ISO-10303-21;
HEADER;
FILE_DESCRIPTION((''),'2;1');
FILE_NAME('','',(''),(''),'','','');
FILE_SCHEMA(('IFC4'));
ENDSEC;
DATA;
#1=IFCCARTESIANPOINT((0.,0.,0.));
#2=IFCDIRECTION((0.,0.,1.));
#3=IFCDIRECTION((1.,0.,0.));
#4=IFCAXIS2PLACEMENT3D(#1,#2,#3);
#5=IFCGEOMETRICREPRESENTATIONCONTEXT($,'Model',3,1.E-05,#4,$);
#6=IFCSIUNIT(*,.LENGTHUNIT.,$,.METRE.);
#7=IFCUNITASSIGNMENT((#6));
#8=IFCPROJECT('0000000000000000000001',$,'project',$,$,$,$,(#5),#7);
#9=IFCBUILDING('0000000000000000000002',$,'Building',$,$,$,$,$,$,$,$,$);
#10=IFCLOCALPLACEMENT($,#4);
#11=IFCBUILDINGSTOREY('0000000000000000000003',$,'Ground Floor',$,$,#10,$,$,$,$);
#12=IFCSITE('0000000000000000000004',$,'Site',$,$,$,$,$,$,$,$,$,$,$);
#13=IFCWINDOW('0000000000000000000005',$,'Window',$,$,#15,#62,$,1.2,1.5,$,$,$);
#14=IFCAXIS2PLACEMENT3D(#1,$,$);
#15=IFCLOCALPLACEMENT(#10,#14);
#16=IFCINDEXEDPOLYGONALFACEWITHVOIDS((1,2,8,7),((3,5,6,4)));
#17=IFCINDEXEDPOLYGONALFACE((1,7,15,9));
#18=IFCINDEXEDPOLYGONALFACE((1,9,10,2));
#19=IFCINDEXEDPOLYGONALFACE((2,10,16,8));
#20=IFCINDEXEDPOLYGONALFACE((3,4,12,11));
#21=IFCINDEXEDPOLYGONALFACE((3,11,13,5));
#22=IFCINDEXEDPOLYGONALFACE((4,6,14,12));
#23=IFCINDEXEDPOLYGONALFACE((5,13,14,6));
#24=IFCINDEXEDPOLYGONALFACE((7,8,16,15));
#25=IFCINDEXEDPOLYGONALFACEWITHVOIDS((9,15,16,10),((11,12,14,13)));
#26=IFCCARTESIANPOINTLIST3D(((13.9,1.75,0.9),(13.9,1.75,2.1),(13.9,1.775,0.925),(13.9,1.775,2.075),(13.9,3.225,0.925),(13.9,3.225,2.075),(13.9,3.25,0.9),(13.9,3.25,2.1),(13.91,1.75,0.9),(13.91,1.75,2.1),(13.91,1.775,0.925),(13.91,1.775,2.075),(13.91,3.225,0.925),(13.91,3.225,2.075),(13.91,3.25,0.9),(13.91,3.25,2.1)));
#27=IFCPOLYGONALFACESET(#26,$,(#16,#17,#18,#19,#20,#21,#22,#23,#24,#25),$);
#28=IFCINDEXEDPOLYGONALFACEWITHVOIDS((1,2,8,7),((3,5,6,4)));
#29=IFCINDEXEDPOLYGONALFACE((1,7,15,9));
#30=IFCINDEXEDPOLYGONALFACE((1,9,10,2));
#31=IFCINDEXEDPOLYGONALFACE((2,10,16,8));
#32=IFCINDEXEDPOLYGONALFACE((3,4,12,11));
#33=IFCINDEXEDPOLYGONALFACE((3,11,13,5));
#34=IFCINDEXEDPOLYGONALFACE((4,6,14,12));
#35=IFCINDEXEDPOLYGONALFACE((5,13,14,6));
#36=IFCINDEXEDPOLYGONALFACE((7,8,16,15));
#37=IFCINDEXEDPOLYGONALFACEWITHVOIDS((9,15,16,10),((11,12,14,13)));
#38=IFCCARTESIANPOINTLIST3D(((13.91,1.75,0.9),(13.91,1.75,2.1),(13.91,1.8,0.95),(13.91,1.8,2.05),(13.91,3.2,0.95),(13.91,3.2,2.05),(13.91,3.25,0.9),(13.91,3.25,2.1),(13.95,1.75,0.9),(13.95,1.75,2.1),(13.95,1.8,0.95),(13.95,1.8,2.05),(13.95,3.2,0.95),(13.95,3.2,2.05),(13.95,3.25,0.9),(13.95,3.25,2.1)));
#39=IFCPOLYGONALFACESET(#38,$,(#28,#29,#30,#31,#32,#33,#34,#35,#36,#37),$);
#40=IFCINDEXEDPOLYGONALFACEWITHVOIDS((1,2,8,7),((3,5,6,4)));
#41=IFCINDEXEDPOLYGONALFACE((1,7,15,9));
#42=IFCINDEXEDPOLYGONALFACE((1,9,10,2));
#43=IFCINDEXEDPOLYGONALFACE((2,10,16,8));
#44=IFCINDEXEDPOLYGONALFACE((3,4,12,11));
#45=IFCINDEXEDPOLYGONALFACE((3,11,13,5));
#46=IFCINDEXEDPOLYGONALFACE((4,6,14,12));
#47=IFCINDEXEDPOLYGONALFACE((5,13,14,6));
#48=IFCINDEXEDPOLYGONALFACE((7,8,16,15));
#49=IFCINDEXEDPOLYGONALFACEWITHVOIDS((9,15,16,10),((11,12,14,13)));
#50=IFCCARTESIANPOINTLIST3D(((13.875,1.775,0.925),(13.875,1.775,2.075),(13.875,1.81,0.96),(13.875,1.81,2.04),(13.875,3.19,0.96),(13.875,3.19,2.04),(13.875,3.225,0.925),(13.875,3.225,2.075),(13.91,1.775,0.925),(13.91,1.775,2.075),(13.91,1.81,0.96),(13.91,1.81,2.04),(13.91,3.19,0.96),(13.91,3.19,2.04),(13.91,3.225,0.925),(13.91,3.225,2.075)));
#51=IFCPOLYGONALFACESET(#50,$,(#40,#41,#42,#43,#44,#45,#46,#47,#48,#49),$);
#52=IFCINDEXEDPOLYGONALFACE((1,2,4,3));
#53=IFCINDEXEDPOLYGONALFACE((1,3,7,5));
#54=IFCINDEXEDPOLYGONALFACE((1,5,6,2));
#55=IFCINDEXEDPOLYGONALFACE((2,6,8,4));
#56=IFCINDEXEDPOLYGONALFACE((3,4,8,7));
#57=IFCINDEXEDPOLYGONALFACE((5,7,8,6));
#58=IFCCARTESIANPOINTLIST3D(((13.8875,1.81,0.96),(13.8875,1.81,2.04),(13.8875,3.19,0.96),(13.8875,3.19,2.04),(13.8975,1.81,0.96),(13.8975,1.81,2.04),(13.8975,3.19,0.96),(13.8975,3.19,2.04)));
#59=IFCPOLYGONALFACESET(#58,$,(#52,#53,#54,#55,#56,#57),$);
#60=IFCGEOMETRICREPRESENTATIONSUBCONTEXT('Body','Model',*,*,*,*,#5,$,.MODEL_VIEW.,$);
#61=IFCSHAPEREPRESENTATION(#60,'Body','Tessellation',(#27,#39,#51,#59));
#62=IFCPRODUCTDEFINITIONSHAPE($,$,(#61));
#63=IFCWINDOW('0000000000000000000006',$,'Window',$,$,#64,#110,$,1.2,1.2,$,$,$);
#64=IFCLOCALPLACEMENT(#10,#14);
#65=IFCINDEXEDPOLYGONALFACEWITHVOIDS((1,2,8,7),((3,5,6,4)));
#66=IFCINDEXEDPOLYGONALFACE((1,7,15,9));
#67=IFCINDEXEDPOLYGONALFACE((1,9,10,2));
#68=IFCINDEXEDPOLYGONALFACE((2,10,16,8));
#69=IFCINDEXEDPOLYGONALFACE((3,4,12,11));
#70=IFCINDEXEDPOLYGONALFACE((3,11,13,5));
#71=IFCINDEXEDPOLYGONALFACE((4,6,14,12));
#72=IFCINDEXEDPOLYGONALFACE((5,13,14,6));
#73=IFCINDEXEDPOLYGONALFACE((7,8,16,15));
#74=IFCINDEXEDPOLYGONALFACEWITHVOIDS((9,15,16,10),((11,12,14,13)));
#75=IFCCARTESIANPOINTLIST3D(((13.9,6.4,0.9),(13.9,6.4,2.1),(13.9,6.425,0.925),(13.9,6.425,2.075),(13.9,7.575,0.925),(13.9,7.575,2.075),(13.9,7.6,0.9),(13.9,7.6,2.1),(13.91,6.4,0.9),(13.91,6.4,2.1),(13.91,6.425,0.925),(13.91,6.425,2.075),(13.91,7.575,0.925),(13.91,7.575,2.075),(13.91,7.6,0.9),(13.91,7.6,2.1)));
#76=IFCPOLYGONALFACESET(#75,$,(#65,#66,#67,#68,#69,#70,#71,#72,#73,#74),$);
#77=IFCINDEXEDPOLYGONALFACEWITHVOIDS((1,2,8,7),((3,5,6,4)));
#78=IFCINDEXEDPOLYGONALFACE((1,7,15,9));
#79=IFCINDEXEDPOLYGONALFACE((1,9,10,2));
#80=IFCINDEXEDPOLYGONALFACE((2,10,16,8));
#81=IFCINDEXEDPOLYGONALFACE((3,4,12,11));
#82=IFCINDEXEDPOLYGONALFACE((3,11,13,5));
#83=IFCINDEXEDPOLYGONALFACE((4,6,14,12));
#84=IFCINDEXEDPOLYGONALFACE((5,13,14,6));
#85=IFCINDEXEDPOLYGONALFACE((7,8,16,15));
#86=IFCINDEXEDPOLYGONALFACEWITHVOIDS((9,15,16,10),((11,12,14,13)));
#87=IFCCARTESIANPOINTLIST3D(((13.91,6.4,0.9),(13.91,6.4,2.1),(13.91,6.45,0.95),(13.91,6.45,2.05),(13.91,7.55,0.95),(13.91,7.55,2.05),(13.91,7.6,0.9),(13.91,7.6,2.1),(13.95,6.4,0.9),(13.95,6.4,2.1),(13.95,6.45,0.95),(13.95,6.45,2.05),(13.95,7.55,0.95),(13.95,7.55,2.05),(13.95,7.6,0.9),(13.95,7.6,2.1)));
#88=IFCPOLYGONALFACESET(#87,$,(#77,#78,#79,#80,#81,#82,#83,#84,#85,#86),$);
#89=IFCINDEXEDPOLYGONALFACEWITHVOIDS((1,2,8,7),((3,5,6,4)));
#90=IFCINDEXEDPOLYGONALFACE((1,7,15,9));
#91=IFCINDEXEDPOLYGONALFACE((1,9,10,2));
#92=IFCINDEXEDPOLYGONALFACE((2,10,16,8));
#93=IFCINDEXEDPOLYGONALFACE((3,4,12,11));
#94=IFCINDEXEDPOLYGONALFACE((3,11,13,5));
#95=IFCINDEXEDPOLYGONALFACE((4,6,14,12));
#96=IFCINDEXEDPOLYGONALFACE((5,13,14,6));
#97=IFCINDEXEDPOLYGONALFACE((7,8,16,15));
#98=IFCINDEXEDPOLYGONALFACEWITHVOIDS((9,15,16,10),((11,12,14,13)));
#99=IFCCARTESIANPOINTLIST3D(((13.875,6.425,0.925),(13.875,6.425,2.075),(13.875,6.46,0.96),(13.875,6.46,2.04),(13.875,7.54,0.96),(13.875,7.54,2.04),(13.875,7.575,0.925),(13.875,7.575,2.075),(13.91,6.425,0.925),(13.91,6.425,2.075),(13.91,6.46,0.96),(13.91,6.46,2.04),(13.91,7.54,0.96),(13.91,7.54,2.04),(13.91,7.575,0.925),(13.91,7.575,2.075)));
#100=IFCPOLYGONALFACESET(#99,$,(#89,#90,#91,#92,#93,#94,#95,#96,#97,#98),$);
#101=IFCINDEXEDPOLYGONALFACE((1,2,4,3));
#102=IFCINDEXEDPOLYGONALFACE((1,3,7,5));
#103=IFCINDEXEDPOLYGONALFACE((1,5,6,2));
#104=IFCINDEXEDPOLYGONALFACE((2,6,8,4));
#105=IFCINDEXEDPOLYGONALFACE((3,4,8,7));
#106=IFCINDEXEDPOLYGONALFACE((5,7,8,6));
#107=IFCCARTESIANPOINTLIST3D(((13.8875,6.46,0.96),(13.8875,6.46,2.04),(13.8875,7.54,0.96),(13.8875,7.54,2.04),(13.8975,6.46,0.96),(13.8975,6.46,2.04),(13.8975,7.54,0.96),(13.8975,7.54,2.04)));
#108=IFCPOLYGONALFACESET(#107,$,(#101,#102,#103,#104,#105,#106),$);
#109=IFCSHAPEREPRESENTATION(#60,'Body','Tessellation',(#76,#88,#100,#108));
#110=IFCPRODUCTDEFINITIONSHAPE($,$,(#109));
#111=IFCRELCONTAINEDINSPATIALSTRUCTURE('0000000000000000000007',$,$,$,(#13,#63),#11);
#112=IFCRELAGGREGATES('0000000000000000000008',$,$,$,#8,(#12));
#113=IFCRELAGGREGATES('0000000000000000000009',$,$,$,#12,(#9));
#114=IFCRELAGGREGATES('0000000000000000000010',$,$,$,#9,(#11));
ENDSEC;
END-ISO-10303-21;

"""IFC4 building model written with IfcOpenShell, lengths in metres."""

from ifc_helpers import new_model, si_unit, frame, origin_with_axes, place, context, subcontext, project, spatial, line, indexed_curve, outline, extrude, element, save


model = new_model("IFC4")

# Units and contexts
model_context = context("Model", 3, precision=1e-05, world=origin_with_axes())
body_context = subcontext(model_context, "Body", "Model", "MODEL_VIEW")
ifc_project = project(units=[si_unit("LENGTHUNIT", "METRE")], contexts=[model_context])

# Site, building, storey
site = spatial("IfcSite", under=ifc_project, Name="Site")
building = spatial("IfcBuilding", under=site, Name="Building")
storey_placement = place(None, origin_with_axes())
storey = spatial("IfcBuildingStorey", under=building, at=storey_placement, Name="Ground Floor")

# Windows
for number, where, z_axis, x_axis, name in (
    (1, (14.0, 1.75, 0.9), (0.0, 0.0, 1.0), (0.0, 1.0, 0.0), "Window"),
):
    element("IfcWindow", number, at=place(storey_placement, frame(where, z_axis=z_axis, x_axis=x_axis)), inside=storey, Name=name, OverallHeight=1.2, OverallWidth=1.5, context=body_context, shape_type="SweptSolid", body=[
        extrude(outline(indexed_curve([(0.0, 0.0), (1.5, 0.0), (1.5, 1.2), (0.0, 1.2)], segments=[line(1, 2, 3, 4, 1)]), holes=[indexed_curve([(0.025, 0.025), (1.475, 0.025), (1.475, 1.175), (0.025, 1.175)], segments=[line(1, 2, 3, 4, 1)])]), frame((0.0, 0.09, 0.0), z_axis=(0.0, -1.0, 0.0), x_axis=(1.0, 0.0, 0.0)), (0.0, 0.0, -1.0), 0.01),
        extrude(outline(indexed_curve([(0.0, 0.0), (1.5, 0.0), (1.5, 1.2), (0.0, 1.2)], segments=[line(1, 2, 3, 4, 1)]), holes=[indexed_curve([(0.05, 0.05), (1.45, 0.05), (1.45, 1.15), (0.05, 1.15)], segments=[line(1, 2, 3, 4, 1)])]), frame((0.0, 0.05, 0.0), z_axis=(0.0, -1.0, 0.0), x_axis=(1.0, 0.0, 0.0)), (0.0, 0.0, -1.0), 0.04),
        extrude(outline(indexed_curve([(0.0, 0.0), (1.45, 0.0), (1.45, 1.15), (0.0, 1.15)], segments=[line(1, 2, 3, 4, 1)]), holes=[indexed_curve([(0.035, 0.035), (1.415, 0.035), (1.415, 1.115), (0.035, 1.115)], segments=[line(1, 2, 3, 4, 1)])]), frame((0.025, 0.09, 0.025), z_axis=(0.0, -1.0, 0.0), x_axis=(1.0, 0.0, 0.0)), (0.0, 0.0, -1.0), 0.035),
        extrude(outline(indexed_curve([(0.035, 0.035), (1.415, 0.035), (1.415, 1.115), (0.035, 1.115)], segments=[line(1, 2, 3, 4, 1)])), frame((0.025, 0.1025, 0.025), z_axis=(0.0, -1.0, 0.0), x_axis=(1.0, 0.0, 0.0)), (0.0, 0.0, -1.0), 0.01),
    ])
window_1_placement = place(storey_placement, frame((14.0, 6.4, 0.9), z_axis=(0.0, 0.0, 1.0), x_axis=(0.0, 1.0, 0.0)))
element("IfcWindow", 2, at=window_1_placement, inside=storey, Name="Window", OverallHeight=1.2, OverallWidth=1.2, context=body_context, shape_type="SweptSolid", body=[
    extrude(outline(indexed_curve([(0.0, 0.0), (1.2, 0.0), (1.2, 1.2), (0.0, 1.2)], segments=[line(1, 2, 3, 4, 1)]), holes=[indexed_curve([(0.025, 0.025), (1.175, 0.025), (1.175, 1.175), (0.025, 1.175)], segments=[line(1, 2, 3, 4, 1)])]), frame((0.0, 0.09, 0.0), z_axis=(0.0, -1.0, 0.0), x_axis=(1.0, 0.0, 0.0)), (0.0, 0.0, -1.0), 0.01),
    extrude(outline(indexed_curve([(0.0, 0.0), (1.2, 0.0), (1.2, 1.2), (0.0, 1.2)], segments=[line(1, 2, 3, 4, 1)]), holes=[indexed_curve([(0.05, 0.05), (1.15, 0.05), (1.15, 1.15), (0.05, 1.15)], segments=[line(1, 2, 3, 4, 1)])]), frame((0.0, 0.05, 0.0), z_axis=(0.0, -1.0, 0.0), x_axis=(1.0, 0.0, 0.0)), (0.0, 0.0, -1.0), 0.04),
    extrude(outline(indexed_curve([(0.0, 0.0), (1.15, 0.0), (1.15, 1.15), (0.0, 1.15)], segments=[line(1, 2, 3, 4, 1)]), holes=[indexed_curve([(0.035, 0.035), (1.115, 0.035), (1.115, 1.115), (0.035, 1.115)], segments=[line(1, 2, 3, 4, 1)])]), frame((0.025, 0.09, 0.025), z_axis=(0.0, -1.0, 0.0), x_axis=(1.0, 0.0, 0.0)), (0.0, 0.0, -1.0), 0.035),
    extrude(outline(indexed_curve([(0.035, 0.035), (1.115, 0.035), (1.115, 1.115), (0.035, 1.115)], segments=[line(1, 2, 3, 4, 1)])), frame((0.025, 0.1025, 0.025), z_axis=(0.0, -1.0, 0.0), x_axis=(1.0, 0.0, 0.0)), (0.0, 0.0, -1.0), 0.01),
])

save(model, "model.ifc")
